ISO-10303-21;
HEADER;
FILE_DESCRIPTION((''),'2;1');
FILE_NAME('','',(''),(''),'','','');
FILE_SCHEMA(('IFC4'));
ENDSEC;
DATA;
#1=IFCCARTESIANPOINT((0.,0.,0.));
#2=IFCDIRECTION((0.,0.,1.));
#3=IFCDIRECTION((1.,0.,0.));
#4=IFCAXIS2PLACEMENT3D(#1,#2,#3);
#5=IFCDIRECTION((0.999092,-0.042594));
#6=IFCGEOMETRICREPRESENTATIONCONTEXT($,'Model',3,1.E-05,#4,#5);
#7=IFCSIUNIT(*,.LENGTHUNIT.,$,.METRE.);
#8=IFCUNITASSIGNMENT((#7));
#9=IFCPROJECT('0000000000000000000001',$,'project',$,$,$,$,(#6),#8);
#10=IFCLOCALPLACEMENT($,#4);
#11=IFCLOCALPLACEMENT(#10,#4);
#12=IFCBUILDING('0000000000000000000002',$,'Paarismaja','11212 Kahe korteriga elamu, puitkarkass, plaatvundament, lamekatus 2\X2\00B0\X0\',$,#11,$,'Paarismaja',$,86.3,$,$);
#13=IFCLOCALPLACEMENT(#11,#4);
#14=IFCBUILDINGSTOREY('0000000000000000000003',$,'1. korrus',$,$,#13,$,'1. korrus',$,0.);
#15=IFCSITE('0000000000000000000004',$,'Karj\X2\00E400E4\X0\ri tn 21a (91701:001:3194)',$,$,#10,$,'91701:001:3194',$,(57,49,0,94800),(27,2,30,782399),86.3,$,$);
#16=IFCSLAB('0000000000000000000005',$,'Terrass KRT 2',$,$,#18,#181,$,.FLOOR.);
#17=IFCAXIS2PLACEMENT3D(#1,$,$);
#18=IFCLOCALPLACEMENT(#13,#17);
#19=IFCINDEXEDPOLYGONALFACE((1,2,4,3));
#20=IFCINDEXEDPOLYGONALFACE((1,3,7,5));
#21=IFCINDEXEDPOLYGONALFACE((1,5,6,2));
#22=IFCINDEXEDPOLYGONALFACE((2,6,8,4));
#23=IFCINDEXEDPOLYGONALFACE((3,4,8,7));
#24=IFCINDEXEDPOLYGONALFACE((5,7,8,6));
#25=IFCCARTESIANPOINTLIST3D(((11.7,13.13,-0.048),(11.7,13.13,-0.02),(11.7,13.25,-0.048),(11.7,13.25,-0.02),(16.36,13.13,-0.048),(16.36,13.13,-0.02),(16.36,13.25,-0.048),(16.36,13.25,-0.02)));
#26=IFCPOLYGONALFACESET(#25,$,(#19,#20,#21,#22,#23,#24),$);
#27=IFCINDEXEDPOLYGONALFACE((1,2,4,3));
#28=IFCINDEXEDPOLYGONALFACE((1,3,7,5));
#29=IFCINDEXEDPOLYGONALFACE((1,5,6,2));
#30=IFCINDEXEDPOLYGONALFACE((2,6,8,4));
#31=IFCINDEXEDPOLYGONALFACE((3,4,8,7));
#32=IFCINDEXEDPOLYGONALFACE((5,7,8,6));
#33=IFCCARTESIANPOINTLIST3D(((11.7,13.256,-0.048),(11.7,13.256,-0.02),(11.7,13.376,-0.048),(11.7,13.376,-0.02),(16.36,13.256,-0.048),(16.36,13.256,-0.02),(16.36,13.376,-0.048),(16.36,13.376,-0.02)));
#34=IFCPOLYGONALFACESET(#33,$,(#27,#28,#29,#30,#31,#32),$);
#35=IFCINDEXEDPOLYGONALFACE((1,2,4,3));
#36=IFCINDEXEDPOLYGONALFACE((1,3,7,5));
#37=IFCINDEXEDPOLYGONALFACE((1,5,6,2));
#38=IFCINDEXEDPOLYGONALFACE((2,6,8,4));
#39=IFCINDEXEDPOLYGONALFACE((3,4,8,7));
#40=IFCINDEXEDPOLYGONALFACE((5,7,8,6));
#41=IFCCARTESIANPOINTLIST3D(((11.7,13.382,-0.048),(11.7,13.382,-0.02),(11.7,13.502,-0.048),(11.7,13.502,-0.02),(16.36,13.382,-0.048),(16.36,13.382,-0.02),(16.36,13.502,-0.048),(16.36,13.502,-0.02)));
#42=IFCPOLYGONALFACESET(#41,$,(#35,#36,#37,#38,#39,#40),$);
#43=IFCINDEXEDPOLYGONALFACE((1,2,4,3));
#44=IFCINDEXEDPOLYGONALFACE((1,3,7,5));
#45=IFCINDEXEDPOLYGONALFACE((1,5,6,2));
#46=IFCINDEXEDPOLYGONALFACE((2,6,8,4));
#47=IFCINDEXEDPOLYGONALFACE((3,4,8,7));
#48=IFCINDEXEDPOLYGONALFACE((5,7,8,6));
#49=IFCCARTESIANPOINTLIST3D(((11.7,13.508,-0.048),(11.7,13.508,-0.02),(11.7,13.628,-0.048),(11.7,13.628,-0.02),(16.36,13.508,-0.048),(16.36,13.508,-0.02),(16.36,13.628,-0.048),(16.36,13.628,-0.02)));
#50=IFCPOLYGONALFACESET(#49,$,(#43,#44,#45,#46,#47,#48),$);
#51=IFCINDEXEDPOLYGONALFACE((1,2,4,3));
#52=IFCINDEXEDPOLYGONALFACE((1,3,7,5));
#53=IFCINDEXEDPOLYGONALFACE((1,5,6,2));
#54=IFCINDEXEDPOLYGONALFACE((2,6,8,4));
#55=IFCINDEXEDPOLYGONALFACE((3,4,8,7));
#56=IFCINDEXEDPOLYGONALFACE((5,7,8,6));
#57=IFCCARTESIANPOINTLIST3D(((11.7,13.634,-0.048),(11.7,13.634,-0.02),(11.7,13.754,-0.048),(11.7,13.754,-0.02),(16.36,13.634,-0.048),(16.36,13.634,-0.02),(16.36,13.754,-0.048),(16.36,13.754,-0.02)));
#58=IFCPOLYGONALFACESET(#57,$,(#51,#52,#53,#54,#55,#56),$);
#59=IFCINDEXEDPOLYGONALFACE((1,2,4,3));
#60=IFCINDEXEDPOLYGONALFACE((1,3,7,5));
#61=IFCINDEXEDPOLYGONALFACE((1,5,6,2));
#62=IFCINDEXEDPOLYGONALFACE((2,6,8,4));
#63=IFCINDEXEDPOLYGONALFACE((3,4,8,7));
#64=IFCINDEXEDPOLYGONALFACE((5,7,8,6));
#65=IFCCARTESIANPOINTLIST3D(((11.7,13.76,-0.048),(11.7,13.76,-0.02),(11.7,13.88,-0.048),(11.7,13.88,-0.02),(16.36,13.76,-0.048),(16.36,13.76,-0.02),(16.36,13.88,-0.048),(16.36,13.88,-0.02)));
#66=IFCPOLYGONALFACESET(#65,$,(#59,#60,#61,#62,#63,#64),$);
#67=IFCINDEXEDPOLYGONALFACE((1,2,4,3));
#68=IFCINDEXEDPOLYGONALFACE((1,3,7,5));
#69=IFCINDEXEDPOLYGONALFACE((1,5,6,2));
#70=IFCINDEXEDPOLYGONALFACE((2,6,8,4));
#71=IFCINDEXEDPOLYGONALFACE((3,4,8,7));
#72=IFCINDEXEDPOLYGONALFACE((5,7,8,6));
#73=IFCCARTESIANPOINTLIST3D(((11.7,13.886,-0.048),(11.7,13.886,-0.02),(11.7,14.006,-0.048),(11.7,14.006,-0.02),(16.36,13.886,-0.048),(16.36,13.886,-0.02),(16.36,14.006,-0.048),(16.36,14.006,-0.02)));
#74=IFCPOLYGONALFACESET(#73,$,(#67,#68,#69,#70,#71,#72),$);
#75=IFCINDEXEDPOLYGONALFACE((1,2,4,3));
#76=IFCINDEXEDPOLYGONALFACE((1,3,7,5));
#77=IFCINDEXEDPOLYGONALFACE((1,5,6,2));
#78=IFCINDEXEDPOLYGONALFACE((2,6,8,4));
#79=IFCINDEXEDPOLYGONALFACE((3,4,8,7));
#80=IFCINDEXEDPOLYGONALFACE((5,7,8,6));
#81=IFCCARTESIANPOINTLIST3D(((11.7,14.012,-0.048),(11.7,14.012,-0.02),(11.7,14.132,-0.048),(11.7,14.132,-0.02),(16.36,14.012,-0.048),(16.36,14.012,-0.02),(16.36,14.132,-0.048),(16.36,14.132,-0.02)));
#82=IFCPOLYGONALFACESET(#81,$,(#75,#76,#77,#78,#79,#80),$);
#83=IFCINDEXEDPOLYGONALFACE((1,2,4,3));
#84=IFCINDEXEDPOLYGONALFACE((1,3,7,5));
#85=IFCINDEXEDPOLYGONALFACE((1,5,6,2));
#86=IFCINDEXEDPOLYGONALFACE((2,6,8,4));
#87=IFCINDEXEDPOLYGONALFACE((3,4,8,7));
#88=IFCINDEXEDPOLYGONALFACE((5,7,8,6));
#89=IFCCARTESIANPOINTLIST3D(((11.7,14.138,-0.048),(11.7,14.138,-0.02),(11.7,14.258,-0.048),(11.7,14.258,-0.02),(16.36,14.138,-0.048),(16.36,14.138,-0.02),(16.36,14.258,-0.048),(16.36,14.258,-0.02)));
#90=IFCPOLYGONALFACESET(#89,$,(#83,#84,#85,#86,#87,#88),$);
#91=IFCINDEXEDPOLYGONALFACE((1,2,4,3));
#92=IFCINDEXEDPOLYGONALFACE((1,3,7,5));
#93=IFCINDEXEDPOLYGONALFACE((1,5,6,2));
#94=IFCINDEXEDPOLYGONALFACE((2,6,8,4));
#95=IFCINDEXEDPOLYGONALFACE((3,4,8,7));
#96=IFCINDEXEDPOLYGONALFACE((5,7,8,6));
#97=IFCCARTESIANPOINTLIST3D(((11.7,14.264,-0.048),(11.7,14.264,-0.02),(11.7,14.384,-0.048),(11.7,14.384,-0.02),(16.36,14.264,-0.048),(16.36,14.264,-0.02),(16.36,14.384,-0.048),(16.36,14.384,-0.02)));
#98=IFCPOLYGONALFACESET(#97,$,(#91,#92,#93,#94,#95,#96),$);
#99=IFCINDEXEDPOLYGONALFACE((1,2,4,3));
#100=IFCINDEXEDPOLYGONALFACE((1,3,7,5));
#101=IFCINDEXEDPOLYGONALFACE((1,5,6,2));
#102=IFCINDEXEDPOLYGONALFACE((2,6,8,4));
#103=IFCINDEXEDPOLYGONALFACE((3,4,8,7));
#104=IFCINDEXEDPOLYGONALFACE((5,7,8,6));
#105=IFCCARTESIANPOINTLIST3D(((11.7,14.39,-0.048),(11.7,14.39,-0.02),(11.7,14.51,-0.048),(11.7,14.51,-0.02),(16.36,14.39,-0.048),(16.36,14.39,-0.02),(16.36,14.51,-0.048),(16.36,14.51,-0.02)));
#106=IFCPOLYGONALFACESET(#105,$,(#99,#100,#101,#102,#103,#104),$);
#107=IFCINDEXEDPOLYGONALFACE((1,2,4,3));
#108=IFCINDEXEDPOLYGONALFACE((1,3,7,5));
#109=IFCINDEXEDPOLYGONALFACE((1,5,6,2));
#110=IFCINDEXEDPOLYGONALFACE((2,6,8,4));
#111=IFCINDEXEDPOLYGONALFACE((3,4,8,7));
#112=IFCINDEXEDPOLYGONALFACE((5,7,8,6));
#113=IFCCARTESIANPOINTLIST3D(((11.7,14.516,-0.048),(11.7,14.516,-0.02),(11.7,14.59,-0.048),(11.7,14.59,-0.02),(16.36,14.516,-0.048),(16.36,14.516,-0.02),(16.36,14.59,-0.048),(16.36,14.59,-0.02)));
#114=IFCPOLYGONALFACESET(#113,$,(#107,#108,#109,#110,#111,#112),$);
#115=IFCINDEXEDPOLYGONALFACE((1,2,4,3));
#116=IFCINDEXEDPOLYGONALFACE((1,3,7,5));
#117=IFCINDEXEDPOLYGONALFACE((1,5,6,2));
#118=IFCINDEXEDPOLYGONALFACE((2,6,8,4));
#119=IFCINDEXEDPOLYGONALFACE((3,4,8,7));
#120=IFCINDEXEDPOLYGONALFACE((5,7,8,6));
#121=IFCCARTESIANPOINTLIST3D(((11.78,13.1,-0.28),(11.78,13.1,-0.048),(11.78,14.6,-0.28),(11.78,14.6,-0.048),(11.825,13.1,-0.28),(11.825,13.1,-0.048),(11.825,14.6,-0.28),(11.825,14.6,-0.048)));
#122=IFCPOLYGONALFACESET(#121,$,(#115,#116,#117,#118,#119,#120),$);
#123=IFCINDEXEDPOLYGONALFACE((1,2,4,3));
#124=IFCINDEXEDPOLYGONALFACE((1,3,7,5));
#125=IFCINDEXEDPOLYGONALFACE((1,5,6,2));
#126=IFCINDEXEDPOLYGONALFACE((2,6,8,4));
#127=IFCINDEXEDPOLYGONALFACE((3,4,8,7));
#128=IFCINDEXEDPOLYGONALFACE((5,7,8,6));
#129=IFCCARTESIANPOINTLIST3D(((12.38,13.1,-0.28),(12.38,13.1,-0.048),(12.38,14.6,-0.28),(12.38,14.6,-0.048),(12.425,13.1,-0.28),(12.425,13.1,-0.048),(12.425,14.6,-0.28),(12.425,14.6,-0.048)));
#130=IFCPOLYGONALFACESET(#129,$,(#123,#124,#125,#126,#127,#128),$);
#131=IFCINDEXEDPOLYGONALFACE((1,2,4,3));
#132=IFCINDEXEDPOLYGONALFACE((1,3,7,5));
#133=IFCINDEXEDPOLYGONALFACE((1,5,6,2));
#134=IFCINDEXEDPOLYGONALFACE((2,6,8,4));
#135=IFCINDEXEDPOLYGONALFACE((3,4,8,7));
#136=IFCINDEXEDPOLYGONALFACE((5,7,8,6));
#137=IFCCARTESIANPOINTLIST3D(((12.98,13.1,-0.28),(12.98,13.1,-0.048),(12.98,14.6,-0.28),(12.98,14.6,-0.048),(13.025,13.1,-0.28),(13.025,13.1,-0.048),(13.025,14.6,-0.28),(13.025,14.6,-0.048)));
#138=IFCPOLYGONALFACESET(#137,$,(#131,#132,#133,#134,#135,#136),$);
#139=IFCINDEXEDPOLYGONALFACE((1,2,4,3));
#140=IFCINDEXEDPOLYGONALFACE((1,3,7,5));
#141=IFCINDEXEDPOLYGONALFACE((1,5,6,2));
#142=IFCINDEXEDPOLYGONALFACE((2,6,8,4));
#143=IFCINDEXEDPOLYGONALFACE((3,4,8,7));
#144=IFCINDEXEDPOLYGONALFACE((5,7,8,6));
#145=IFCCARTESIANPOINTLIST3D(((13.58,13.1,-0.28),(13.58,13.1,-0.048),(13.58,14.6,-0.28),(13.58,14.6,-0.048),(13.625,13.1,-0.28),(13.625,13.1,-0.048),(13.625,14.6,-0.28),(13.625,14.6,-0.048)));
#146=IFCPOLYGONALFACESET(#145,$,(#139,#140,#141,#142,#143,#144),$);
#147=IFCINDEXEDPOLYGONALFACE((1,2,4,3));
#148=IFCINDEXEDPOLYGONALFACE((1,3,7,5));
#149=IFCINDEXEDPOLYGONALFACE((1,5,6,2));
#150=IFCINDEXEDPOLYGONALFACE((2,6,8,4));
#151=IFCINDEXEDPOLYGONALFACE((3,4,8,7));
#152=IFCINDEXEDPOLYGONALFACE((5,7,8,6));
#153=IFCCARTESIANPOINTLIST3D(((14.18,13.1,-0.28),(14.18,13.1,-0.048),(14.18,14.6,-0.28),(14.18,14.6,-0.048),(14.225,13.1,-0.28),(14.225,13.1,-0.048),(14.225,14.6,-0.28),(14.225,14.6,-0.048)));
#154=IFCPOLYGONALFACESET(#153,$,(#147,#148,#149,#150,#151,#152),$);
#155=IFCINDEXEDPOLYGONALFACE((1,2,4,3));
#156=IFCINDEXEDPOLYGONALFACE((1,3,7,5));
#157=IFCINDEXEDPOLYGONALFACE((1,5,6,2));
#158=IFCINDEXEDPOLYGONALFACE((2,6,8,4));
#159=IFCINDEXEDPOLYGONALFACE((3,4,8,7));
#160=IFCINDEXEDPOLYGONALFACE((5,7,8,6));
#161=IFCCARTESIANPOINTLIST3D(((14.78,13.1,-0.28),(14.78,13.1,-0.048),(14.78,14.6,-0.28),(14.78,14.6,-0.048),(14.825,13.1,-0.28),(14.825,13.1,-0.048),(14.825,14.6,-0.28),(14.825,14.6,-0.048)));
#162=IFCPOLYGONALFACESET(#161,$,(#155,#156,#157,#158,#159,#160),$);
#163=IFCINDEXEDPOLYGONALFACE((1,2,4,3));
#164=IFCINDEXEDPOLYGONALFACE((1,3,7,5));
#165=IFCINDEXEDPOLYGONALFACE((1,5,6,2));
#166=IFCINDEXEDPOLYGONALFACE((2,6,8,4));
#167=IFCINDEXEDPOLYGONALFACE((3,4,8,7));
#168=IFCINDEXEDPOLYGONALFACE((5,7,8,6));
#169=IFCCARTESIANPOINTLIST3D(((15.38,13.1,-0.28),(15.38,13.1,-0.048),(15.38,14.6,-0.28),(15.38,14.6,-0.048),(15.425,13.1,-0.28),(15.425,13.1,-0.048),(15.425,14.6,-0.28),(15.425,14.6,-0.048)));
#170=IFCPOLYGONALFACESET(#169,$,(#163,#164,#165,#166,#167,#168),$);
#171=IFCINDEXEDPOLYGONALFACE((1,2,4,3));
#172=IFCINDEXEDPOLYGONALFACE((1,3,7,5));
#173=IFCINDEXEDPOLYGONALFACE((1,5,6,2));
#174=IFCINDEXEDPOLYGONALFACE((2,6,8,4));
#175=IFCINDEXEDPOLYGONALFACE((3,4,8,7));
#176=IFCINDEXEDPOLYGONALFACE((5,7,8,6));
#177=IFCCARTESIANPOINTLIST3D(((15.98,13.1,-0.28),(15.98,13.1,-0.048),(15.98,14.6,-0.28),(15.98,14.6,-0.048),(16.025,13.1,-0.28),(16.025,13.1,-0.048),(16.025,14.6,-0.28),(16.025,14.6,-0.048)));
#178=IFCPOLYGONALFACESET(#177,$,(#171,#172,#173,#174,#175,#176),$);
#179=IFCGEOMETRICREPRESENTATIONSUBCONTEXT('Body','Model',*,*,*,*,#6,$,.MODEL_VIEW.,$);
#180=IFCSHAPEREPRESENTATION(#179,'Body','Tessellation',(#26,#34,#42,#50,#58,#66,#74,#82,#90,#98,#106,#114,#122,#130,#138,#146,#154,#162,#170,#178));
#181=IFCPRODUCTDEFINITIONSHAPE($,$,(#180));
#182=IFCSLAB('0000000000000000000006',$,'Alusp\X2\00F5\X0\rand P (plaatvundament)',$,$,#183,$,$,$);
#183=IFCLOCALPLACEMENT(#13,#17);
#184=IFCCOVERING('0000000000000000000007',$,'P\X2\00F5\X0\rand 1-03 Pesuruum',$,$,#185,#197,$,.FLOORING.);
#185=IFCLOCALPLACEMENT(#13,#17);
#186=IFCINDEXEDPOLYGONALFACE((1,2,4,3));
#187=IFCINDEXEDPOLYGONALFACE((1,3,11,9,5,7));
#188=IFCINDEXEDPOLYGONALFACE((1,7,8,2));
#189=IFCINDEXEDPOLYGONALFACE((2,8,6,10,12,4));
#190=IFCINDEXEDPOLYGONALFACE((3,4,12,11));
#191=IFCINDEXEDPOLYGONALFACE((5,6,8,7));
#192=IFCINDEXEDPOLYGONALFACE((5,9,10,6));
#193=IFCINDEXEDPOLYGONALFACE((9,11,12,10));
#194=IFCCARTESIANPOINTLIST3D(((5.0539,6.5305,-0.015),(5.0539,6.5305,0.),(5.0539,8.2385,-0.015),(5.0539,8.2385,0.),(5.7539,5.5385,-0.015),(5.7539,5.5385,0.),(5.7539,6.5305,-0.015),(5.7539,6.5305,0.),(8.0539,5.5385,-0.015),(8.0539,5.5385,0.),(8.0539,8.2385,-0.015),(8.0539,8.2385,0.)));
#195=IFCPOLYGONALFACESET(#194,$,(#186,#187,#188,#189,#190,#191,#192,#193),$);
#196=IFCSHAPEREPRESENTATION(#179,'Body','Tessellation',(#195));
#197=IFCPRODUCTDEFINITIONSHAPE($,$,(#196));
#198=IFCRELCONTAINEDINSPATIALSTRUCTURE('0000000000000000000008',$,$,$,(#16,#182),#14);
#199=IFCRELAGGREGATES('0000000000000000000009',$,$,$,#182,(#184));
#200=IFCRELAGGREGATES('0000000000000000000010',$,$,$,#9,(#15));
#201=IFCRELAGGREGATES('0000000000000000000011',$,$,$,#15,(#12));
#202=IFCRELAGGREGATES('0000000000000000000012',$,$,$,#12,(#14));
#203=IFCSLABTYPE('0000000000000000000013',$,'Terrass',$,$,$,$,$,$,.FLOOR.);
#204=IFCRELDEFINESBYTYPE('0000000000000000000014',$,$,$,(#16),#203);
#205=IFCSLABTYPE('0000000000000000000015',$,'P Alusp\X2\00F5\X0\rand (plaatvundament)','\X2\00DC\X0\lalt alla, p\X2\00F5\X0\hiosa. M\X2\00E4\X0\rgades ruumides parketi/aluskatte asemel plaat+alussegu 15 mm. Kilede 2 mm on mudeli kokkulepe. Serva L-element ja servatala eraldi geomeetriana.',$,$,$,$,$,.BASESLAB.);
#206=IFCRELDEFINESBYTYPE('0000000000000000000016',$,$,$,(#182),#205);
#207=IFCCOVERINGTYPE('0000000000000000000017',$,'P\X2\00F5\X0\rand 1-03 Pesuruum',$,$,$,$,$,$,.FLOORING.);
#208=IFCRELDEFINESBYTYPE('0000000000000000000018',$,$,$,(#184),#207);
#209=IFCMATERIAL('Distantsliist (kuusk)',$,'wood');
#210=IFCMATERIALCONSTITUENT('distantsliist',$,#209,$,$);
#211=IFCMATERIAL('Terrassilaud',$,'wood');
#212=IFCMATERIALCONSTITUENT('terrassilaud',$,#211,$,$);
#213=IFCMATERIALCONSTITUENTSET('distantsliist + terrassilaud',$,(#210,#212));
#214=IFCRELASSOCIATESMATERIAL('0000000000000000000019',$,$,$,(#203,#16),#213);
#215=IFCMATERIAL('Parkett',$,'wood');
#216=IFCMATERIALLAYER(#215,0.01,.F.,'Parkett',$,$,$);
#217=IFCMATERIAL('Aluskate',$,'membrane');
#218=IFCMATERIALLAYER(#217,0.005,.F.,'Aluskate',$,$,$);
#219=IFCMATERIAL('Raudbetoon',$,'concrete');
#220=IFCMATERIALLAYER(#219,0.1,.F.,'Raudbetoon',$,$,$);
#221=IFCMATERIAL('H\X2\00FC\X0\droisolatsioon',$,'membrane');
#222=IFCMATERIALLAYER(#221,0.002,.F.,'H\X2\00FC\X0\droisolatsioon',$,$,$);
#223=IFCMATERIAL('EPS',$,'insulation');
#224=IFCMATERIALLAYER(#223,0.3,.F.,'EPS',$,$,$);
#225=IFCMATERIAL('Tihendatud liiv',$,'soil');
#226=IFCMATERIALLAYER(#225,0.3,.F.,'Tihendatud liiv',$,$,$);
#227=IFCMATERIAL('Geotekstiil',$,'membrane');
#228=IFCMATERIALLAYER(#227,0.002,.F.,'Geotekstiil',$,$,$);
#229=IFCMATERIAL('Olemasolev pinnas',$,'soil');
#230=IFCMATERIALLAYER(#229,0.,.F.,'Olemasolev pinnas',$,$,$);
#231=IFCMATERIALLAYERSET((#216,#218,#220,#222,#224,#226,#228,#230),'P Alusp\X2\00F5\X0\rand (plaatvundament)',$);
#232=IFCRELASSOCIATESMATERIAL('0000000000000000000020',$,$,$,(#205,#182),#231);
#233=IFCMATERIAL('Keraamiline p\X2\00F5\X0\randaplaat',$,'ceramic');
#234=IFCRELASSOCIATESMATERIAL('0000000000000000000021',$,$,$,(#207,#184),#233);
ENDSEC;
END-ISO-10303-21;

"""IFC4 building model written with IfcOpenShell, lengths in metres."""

from ifc_helpers import new_model, si_unit, direction, frame, origin_with_axes, place, context, subcontext, project, spatial, indexed_curve, outline, extrude, material, layer, layer_set, layer_usage, constituent, constituent_set, type_object, element, aggregate, save


model = new_model("IFC4")

# Units and contexts
model_context = context("Model", 3, precision=1e-05, world=origin_with_axes(), true_north=direction((0.999092, -0.042594)))
body_context = subcontext(model_context, "Body", "Model", "MODEL_VIEW")
ifc_project = project(units=[si_unit("LENGTHUNIT", "METRE")], contexts=[model_context])

# Site, building, storey
site_placement = place(None, origin_with_axes())
site = spatial("IfcSite", under=ifc_project, at=site_placement, Name="Karjääri tn 21a (91701:001:3194)", LongName="91701:001:3194", RefLatitude=(57, 49, 0, 94800), RefLongitude=(27, 2, 30, 782399), RefElevation=86.3)
building_placement = place(site_placement, origin_with_axes())
building = spatial("IfcBuilding", under=site, at=building_placement, Name="Paarismaja", Description="11212 Kahe korteriga elamu, puitkarkass, plaatvundament, lamekatus 2°", LongName="Paarismaja", ElevationOfRefHeight=86.3)
storey_placement = place(building_placement, origin_with_axes())
storey = spatial("IfcBuildingStorey", under=building, at=storey_placement, Name="1. korrus", LongName="1. korrus", Elevation=0.0)

# Slab
ifc_material_1 = material(Name="Distantsliist (kuusk)", Category="wood")
ifc_constituent_1 = constituent(ifc_material_1, Name="distantsliist")
ifc_material_2 = material(Name="Terrassilaud", Category="wood")
ifc_constituent_2 = constituent(ifc_material_2, Name="terrassilaud")
ifc_constituent_set_1 = constituent_set(constituents=[ifc_constituent_1, ifc_constituent_2], Name="distantsliist + terrassilaud")
slab_type_1 = type_object("IfcSlabType", Name="Terrass", PredefinedType="FLOOR", material=ifc_constituent_set_1)
slab_1_placement = place(storey_placement, origin_with_axes())
element("IfcSlab", 1, at=slab_1_placement, inside=storey, type_object=slab_type_1, material=ifc_constituent_set_1, Name="Terrass KRT 2", PredefinedType="FLOOR", context=body_context, shape_type="SweptSolid", body=[
    extrude(outline(indexed_curve([(11.7, 13.13), (16.36, 13.13), (16.36, 13.25), (11.7, 13.25), (11.7, 13.13)], self_intersect=False)), frame((0.0, 0.0, -0.048), z_axis=(0.0, 0.0, 1.0), x_axis=(1.0, 0.0, 0.0)), (0.0, 0.0, 1.0), 0.028),
    extrude(outline(indexed_curve([(11.7, 13.256), (16.36, 13.256), (16.36, 13.376), (11.7, 13.376), (11.7, 13.256)], self_intersect=False)), frame((0.0, 0.0, -0.048), z_axis=(0.0, 0.0, 1.0), x_axis=(1.0, 0.0, 0.0)), (0.0, 0.0, 1.0), 0.028),
    extrude(outline(indexed_curve([(11.7, 13.382), (16.36, 13.382), (16.36, 13.502), (11.7, 13.502), (11.7, 13.382)], self_intersect=False)), frame((0.0, 0.0, -0.048), z_axis=(0.0, 0.0, 1.0), x_axis=(1.0, 0.0, 0.0)), (0.0, 0.0, 1.0), 0.028),
    extrude(outline(indexed_curve([(11.7, 13.508), (16.36, 13.508), (16.36, 13.628), (11.7, 13.628), (11.7, 13.508)], self_intersect=False)), frame((0.0, 0.0, -0.048), z_axis=(0.0, 0.0, 1.0), x_axis=(1.0, 0.0, 0.0)), (0.0, 0.0, 1.0), 0.028),
    extrude(outline(indexed_curve([(11.7, 13.634), (16.36, 13.634), (16.36, 13.754), (11.7, 13.754), (11.7, 13.634)], self_intersect=False)), frame((0.0, 0.0, -0.048), z_axis=(0.0, 0.0, 1.0), x_axis=(1.0, 0.0, 0.0)), (0.0, 0.0, 1.0), 0.028),
    extrude(outline(indexed_curve([(11.7, 13.76), (16.36, 13.76), (16.36, 13.88), (11.7, 13.88), (11.7, 13.76)], self_intersect=False)), frame((0.0, 0.0, -0.048), z_axis=(0.0, 0.0, 1.0), x_axis=(1.0, 0.0, 0.0)), (0.0, 0.0, 1.0), 0.028),
    extrude(outline(indexed_curve([(11.7, 13.886), (16.36, 13.886), (16.36, 14.006), (11.7, 14.006), (11.7, 13.886)], self_intersect=False)), frame((0.0, 0.0, -0.048), z_axis=(0.0, 0.0, 1.0), x_axis=(1.0, 0.0, 0.0)), (0.0, 0.0, 1.0), 0.028),
    extrude(outline(indexed_curve([(11.7, 14.012), (16.36, 14.012), (16.36, 14.132), (11.7, 14.132), (11.7, 14.012)], self_intersect=False)), frame((0.0, 0.0, -0.048), z_axis=(0.0, 0.0, 1.0), x_axis=(1.0, 0.0, 0.0)), (0.0, 0.0, 1.0), 0.028),
    extrude(outline(indexed_curve([(11.7, 14.138), (16.36, 14.138), (16.36, 14.258), (11.7, 14.258), (11.7, 14.138)], self_intersect=False)), frame((0.0, 0.0, -0.048), z_axis=(0.0, 0.0, 1.0), x_axis=(1.0, 0.0, 0.0)), (0.0, 0.0, 1.0), 0.028),
    extrude(outline(indexed_curve([(11.7, 14.264), (16.36, 14.264), (16.36, 14.384), (11.7, 14.384), (11.7, 14.264)], self_intersect=False)), frame((0.0, 0.0, -0.048), z_axis=(0.0, 0.0, 1.0), x_axis=(1.0, 0.0, 0.0)), (0.0, 0.0, 1.0), 0.028),
    extrude(outline(indexed_curve([(11.7, 14.39), (16.36, 14.39), (16.36, 14.51), (11.7, 14.51), (11.7, 14.39)], self_intersect=False)), frame((0.0, 0.0, -0.048), z_axis=(0.0, 0.0, 1.0), x_axis=(1.0, 0.0, 0.0)), (0.0, 0.0, 1.0), 0.028),
    extrude(outline(indexed_curve([(11.7, 14.516), (16.36, 14.516), (16.36, 14.59), (11.7, 14.59), (11.7, 14.516)], self_intersect=False)), frame((0.0, 0.0, -0.048), z_axis=(0.0, 0.0, 1.0), x_axis=(1.0, 0.0, 0.0)), (0.0, 0.0, 1.0), 0.028),
    extrude(outline(indexed_curve([(11.78, 13.1), (11.825, 13.1), (11.825, 14.6), (11.78, 14.6), (11.78, 13.1)], self_intersect=False)), frame((0.0, 0.0, -0.28), z_axis=(0.0, 0.0, 1.0), x_axis=(1.0, 0.0, 0.0)), (0.0, 0.0, 1.0), 0.232),
    extrude(outline(indexed_curve([(12.38, 13.1), (12.425, 13.1), (12.425, 14.6), (12.38, 14.6), (12.38, 13.1)], self_intersect=False)), frame((0.0, 0.0, -0.28), z_axis=(0.0, 0.0, 1.0), x_axis=(1.0, 0.0, 0.0)), (0.0, 0.0, 1.0), 0.232),
    extrude(outline(indexed_curve([(12.98, 13.1), (13.025, 13.1), (13.025, 14.6), (12.98, 14.6), (12.98, 13.1)], self_intersect=False)), frame((0.0, 0.0, -0.28), z_axis=(0.0, 0.0, 1.0), x_axis=(1.0, 0.0, 0.0)), (0.0, 0.0, 1.0), 0.232),
    extrude(outline(indexed_curve([(13.58, 13.1), (13.625, 13.1), (13.625, 14.6), (13.58, 14.6), (13.58, 13.1)], self_intersect=False)), frame((0.0, 0.0, -0.28), z_axis=(0.0, 0.0, 1.0), x_axis=(1.0, 0.0, 0.0)), (0.0, 0.0, 1.0), 0.232),
    extrude(outline(indexed_curve([(14.18, 13.1), (14.225, 13.1), (14.225, 14.6), (14.18, 14.6), (14.18, 13.1)], self_intersect=False)), frame((0.0, 0.0, -0.28), z_axis=(0.0, 0.0, 1.0), x_axis=(1.0, 0.0, 0.0)), (0.0, 0.0, 1.0), 0.232),
    extrude(outline(indexed_curve([(14.78, 13.1), (14.825, 13.1), (14.825, 14.6), (14.78, 14.6), (14.78, 13.1)], self_intersect=False)), frame((0.0, 0.0, -0.28), z_axis=(0.0, 0.0, 1.0), x_axis=(1.0, 0.0, 0.0)), (0.0, 0.0, 1.0), 0.232),
    extrude(outline(indexed_curve([(15.38, 13.1), (15.425, 13.1), (15.425, 14.6), (15.38, 14.6), (15.38, 13.1)], self_intersect=False)), frame((0.0, 0.0, -0.28), z_axis=(0.0, 0.0, 1.0), x_axis=(1.0, 0.0, 0.0)), (0.0, 0.0, 1.0), 0.232),
    extrude(outline(indexed_curve([(15.98, 13.1), (16.025, 13.1), (16.025, 14.6), (15.98, 14.6), (15.98, 13.1)], self_intersect=False)), frame((0.0, 0.0, -0.28), z_axis=(0.0, 0.0, 1.0), x_axis=(1.0, 0.0, 0.0)), (0.0, 0.0, 1.0), 0.232),
])

# Slab, covering
ifc_material_3 = material(Name="Parkett", Category="wood")
ifc_layer_1 = layer(ifc_material_3, 0.01, ventilated=False, Name="Parkett")
ifc_material_4 = material(Name="Aluskate", Category="membrane")
ifc_layer_2 = layer(ifc_material_4, 0.005, ventilated=False, Name="Aluskate")
ifc_material_5 = material(Name="Raudbetoon", Category="concrete")
ifc_layer_3 = layer(ifc_material_5, 0.1, ventilated=False, Name="Raudbetoon")
ifc_material_6 = material(Name="Hüdroisolatsioon", Category="membrane")
ifc_layer_4 = layer(ifc_material_6, 0.002, ventilated=False, Name="Hüdroisolatsioon")
ifc_material_7 = material(Name="EPS", Category="insulation")
ifc_layer_5 = layer(ifc_material_7, 0.3, ventilated=False, Name="EPS")
ifc_material_8 = material(Name="Tihendatud liiv", Category="soil")
ifc_layer_6 = layer(ifc_material_8, 0.3, ventilated=False, Name="Tihendatud liiv")
ifc_material_9 = material(Name="Geotekstiil", Category="membrane")
ifc_layer_7 = layer(ifc_material_9, 0.002, ventilated=False, Name="Geotekstiil")
ifc_material_10 = material(Name="Olemasolev pinnas", Category="soil")
ifc_layer_8 = layer(ifc_material_10, 0.0, ventilated=False, Name="Olemasolev pinnas")
ifc_layer_set = layer_set([ifc_layer_1, ifc_layer_2, ifc_layer_3, ifc_layer_4, ifc_layer_5, ifc_layer_6, ifc_layer_7, ifc_layer_8], Name="P Aluspõrand (plaatvundament)")
ifc_layer_usage = layer_usage(ifc_layer_set, "AXIS3", "NEGATIVE", 0.0)
slab_type_2 = type_object("IfcSlabType", Name="P Aluspõrand (plaatvundament)", Description="Ülalt alla, põhiosa. Märgades ruumides parketi/aluskatte asemel plaat+alussegu 15 mm. Kilede 2 mm on mudeli kokkulepe. Serva L-element ja servatala eraldi geomeetriana.", PredefinedType="BASESLAB", material=ifc_layer_set)
slab_2_placement = place(storey_placement, origin_with_axes())
slab_2 = element("IfcSlab", 2, at=slab_2_placement, inside=storey, type_object=slab_type_2, material=ifc_layer_usage, Name="Aluspõrand P (plaatvundament)")
ifc_material_11 = material(Name="Keraamiline põrandaplaat", Category="ceramic")
covering_type_1 = type_object("IfcCoveringType", Name="Põrand 1-03 Pesuruum", PredefinedType="FLOORING", material=ifc_material_11)
covering_1_placement = place(slab_2_placement, origin_with_axes())
covering_1 = element("IfcCovering", 3, at=covering_1_placement, type_object=covering_type_1, material=ifc_material_11, Name="Põrand 1-03 Pesuruum", PredefinedType="FLOORING", context=body_context, shape_type="SweptSolid", body=[
    extrude(outline(indexed_curve([(8.0539, 8.2385), (8.0539, 5.5385), (5.7539, 5.5385), (5.7539, 6.5305), (5.0539, 6.5305), (5.0539, 8.2385), (8.0539, 8.2385)], self_intersect=False)), frame((0.0, 0.0, -0.015), z_axis=(0.0, 0.0, 1.0), x_axis=(1.0, 0.0, 0.0)), (0.0, 0.0, 1.0), 0.015),
])

aggregate(slab_2, [covering_1])

save(model, "model.ifc")
